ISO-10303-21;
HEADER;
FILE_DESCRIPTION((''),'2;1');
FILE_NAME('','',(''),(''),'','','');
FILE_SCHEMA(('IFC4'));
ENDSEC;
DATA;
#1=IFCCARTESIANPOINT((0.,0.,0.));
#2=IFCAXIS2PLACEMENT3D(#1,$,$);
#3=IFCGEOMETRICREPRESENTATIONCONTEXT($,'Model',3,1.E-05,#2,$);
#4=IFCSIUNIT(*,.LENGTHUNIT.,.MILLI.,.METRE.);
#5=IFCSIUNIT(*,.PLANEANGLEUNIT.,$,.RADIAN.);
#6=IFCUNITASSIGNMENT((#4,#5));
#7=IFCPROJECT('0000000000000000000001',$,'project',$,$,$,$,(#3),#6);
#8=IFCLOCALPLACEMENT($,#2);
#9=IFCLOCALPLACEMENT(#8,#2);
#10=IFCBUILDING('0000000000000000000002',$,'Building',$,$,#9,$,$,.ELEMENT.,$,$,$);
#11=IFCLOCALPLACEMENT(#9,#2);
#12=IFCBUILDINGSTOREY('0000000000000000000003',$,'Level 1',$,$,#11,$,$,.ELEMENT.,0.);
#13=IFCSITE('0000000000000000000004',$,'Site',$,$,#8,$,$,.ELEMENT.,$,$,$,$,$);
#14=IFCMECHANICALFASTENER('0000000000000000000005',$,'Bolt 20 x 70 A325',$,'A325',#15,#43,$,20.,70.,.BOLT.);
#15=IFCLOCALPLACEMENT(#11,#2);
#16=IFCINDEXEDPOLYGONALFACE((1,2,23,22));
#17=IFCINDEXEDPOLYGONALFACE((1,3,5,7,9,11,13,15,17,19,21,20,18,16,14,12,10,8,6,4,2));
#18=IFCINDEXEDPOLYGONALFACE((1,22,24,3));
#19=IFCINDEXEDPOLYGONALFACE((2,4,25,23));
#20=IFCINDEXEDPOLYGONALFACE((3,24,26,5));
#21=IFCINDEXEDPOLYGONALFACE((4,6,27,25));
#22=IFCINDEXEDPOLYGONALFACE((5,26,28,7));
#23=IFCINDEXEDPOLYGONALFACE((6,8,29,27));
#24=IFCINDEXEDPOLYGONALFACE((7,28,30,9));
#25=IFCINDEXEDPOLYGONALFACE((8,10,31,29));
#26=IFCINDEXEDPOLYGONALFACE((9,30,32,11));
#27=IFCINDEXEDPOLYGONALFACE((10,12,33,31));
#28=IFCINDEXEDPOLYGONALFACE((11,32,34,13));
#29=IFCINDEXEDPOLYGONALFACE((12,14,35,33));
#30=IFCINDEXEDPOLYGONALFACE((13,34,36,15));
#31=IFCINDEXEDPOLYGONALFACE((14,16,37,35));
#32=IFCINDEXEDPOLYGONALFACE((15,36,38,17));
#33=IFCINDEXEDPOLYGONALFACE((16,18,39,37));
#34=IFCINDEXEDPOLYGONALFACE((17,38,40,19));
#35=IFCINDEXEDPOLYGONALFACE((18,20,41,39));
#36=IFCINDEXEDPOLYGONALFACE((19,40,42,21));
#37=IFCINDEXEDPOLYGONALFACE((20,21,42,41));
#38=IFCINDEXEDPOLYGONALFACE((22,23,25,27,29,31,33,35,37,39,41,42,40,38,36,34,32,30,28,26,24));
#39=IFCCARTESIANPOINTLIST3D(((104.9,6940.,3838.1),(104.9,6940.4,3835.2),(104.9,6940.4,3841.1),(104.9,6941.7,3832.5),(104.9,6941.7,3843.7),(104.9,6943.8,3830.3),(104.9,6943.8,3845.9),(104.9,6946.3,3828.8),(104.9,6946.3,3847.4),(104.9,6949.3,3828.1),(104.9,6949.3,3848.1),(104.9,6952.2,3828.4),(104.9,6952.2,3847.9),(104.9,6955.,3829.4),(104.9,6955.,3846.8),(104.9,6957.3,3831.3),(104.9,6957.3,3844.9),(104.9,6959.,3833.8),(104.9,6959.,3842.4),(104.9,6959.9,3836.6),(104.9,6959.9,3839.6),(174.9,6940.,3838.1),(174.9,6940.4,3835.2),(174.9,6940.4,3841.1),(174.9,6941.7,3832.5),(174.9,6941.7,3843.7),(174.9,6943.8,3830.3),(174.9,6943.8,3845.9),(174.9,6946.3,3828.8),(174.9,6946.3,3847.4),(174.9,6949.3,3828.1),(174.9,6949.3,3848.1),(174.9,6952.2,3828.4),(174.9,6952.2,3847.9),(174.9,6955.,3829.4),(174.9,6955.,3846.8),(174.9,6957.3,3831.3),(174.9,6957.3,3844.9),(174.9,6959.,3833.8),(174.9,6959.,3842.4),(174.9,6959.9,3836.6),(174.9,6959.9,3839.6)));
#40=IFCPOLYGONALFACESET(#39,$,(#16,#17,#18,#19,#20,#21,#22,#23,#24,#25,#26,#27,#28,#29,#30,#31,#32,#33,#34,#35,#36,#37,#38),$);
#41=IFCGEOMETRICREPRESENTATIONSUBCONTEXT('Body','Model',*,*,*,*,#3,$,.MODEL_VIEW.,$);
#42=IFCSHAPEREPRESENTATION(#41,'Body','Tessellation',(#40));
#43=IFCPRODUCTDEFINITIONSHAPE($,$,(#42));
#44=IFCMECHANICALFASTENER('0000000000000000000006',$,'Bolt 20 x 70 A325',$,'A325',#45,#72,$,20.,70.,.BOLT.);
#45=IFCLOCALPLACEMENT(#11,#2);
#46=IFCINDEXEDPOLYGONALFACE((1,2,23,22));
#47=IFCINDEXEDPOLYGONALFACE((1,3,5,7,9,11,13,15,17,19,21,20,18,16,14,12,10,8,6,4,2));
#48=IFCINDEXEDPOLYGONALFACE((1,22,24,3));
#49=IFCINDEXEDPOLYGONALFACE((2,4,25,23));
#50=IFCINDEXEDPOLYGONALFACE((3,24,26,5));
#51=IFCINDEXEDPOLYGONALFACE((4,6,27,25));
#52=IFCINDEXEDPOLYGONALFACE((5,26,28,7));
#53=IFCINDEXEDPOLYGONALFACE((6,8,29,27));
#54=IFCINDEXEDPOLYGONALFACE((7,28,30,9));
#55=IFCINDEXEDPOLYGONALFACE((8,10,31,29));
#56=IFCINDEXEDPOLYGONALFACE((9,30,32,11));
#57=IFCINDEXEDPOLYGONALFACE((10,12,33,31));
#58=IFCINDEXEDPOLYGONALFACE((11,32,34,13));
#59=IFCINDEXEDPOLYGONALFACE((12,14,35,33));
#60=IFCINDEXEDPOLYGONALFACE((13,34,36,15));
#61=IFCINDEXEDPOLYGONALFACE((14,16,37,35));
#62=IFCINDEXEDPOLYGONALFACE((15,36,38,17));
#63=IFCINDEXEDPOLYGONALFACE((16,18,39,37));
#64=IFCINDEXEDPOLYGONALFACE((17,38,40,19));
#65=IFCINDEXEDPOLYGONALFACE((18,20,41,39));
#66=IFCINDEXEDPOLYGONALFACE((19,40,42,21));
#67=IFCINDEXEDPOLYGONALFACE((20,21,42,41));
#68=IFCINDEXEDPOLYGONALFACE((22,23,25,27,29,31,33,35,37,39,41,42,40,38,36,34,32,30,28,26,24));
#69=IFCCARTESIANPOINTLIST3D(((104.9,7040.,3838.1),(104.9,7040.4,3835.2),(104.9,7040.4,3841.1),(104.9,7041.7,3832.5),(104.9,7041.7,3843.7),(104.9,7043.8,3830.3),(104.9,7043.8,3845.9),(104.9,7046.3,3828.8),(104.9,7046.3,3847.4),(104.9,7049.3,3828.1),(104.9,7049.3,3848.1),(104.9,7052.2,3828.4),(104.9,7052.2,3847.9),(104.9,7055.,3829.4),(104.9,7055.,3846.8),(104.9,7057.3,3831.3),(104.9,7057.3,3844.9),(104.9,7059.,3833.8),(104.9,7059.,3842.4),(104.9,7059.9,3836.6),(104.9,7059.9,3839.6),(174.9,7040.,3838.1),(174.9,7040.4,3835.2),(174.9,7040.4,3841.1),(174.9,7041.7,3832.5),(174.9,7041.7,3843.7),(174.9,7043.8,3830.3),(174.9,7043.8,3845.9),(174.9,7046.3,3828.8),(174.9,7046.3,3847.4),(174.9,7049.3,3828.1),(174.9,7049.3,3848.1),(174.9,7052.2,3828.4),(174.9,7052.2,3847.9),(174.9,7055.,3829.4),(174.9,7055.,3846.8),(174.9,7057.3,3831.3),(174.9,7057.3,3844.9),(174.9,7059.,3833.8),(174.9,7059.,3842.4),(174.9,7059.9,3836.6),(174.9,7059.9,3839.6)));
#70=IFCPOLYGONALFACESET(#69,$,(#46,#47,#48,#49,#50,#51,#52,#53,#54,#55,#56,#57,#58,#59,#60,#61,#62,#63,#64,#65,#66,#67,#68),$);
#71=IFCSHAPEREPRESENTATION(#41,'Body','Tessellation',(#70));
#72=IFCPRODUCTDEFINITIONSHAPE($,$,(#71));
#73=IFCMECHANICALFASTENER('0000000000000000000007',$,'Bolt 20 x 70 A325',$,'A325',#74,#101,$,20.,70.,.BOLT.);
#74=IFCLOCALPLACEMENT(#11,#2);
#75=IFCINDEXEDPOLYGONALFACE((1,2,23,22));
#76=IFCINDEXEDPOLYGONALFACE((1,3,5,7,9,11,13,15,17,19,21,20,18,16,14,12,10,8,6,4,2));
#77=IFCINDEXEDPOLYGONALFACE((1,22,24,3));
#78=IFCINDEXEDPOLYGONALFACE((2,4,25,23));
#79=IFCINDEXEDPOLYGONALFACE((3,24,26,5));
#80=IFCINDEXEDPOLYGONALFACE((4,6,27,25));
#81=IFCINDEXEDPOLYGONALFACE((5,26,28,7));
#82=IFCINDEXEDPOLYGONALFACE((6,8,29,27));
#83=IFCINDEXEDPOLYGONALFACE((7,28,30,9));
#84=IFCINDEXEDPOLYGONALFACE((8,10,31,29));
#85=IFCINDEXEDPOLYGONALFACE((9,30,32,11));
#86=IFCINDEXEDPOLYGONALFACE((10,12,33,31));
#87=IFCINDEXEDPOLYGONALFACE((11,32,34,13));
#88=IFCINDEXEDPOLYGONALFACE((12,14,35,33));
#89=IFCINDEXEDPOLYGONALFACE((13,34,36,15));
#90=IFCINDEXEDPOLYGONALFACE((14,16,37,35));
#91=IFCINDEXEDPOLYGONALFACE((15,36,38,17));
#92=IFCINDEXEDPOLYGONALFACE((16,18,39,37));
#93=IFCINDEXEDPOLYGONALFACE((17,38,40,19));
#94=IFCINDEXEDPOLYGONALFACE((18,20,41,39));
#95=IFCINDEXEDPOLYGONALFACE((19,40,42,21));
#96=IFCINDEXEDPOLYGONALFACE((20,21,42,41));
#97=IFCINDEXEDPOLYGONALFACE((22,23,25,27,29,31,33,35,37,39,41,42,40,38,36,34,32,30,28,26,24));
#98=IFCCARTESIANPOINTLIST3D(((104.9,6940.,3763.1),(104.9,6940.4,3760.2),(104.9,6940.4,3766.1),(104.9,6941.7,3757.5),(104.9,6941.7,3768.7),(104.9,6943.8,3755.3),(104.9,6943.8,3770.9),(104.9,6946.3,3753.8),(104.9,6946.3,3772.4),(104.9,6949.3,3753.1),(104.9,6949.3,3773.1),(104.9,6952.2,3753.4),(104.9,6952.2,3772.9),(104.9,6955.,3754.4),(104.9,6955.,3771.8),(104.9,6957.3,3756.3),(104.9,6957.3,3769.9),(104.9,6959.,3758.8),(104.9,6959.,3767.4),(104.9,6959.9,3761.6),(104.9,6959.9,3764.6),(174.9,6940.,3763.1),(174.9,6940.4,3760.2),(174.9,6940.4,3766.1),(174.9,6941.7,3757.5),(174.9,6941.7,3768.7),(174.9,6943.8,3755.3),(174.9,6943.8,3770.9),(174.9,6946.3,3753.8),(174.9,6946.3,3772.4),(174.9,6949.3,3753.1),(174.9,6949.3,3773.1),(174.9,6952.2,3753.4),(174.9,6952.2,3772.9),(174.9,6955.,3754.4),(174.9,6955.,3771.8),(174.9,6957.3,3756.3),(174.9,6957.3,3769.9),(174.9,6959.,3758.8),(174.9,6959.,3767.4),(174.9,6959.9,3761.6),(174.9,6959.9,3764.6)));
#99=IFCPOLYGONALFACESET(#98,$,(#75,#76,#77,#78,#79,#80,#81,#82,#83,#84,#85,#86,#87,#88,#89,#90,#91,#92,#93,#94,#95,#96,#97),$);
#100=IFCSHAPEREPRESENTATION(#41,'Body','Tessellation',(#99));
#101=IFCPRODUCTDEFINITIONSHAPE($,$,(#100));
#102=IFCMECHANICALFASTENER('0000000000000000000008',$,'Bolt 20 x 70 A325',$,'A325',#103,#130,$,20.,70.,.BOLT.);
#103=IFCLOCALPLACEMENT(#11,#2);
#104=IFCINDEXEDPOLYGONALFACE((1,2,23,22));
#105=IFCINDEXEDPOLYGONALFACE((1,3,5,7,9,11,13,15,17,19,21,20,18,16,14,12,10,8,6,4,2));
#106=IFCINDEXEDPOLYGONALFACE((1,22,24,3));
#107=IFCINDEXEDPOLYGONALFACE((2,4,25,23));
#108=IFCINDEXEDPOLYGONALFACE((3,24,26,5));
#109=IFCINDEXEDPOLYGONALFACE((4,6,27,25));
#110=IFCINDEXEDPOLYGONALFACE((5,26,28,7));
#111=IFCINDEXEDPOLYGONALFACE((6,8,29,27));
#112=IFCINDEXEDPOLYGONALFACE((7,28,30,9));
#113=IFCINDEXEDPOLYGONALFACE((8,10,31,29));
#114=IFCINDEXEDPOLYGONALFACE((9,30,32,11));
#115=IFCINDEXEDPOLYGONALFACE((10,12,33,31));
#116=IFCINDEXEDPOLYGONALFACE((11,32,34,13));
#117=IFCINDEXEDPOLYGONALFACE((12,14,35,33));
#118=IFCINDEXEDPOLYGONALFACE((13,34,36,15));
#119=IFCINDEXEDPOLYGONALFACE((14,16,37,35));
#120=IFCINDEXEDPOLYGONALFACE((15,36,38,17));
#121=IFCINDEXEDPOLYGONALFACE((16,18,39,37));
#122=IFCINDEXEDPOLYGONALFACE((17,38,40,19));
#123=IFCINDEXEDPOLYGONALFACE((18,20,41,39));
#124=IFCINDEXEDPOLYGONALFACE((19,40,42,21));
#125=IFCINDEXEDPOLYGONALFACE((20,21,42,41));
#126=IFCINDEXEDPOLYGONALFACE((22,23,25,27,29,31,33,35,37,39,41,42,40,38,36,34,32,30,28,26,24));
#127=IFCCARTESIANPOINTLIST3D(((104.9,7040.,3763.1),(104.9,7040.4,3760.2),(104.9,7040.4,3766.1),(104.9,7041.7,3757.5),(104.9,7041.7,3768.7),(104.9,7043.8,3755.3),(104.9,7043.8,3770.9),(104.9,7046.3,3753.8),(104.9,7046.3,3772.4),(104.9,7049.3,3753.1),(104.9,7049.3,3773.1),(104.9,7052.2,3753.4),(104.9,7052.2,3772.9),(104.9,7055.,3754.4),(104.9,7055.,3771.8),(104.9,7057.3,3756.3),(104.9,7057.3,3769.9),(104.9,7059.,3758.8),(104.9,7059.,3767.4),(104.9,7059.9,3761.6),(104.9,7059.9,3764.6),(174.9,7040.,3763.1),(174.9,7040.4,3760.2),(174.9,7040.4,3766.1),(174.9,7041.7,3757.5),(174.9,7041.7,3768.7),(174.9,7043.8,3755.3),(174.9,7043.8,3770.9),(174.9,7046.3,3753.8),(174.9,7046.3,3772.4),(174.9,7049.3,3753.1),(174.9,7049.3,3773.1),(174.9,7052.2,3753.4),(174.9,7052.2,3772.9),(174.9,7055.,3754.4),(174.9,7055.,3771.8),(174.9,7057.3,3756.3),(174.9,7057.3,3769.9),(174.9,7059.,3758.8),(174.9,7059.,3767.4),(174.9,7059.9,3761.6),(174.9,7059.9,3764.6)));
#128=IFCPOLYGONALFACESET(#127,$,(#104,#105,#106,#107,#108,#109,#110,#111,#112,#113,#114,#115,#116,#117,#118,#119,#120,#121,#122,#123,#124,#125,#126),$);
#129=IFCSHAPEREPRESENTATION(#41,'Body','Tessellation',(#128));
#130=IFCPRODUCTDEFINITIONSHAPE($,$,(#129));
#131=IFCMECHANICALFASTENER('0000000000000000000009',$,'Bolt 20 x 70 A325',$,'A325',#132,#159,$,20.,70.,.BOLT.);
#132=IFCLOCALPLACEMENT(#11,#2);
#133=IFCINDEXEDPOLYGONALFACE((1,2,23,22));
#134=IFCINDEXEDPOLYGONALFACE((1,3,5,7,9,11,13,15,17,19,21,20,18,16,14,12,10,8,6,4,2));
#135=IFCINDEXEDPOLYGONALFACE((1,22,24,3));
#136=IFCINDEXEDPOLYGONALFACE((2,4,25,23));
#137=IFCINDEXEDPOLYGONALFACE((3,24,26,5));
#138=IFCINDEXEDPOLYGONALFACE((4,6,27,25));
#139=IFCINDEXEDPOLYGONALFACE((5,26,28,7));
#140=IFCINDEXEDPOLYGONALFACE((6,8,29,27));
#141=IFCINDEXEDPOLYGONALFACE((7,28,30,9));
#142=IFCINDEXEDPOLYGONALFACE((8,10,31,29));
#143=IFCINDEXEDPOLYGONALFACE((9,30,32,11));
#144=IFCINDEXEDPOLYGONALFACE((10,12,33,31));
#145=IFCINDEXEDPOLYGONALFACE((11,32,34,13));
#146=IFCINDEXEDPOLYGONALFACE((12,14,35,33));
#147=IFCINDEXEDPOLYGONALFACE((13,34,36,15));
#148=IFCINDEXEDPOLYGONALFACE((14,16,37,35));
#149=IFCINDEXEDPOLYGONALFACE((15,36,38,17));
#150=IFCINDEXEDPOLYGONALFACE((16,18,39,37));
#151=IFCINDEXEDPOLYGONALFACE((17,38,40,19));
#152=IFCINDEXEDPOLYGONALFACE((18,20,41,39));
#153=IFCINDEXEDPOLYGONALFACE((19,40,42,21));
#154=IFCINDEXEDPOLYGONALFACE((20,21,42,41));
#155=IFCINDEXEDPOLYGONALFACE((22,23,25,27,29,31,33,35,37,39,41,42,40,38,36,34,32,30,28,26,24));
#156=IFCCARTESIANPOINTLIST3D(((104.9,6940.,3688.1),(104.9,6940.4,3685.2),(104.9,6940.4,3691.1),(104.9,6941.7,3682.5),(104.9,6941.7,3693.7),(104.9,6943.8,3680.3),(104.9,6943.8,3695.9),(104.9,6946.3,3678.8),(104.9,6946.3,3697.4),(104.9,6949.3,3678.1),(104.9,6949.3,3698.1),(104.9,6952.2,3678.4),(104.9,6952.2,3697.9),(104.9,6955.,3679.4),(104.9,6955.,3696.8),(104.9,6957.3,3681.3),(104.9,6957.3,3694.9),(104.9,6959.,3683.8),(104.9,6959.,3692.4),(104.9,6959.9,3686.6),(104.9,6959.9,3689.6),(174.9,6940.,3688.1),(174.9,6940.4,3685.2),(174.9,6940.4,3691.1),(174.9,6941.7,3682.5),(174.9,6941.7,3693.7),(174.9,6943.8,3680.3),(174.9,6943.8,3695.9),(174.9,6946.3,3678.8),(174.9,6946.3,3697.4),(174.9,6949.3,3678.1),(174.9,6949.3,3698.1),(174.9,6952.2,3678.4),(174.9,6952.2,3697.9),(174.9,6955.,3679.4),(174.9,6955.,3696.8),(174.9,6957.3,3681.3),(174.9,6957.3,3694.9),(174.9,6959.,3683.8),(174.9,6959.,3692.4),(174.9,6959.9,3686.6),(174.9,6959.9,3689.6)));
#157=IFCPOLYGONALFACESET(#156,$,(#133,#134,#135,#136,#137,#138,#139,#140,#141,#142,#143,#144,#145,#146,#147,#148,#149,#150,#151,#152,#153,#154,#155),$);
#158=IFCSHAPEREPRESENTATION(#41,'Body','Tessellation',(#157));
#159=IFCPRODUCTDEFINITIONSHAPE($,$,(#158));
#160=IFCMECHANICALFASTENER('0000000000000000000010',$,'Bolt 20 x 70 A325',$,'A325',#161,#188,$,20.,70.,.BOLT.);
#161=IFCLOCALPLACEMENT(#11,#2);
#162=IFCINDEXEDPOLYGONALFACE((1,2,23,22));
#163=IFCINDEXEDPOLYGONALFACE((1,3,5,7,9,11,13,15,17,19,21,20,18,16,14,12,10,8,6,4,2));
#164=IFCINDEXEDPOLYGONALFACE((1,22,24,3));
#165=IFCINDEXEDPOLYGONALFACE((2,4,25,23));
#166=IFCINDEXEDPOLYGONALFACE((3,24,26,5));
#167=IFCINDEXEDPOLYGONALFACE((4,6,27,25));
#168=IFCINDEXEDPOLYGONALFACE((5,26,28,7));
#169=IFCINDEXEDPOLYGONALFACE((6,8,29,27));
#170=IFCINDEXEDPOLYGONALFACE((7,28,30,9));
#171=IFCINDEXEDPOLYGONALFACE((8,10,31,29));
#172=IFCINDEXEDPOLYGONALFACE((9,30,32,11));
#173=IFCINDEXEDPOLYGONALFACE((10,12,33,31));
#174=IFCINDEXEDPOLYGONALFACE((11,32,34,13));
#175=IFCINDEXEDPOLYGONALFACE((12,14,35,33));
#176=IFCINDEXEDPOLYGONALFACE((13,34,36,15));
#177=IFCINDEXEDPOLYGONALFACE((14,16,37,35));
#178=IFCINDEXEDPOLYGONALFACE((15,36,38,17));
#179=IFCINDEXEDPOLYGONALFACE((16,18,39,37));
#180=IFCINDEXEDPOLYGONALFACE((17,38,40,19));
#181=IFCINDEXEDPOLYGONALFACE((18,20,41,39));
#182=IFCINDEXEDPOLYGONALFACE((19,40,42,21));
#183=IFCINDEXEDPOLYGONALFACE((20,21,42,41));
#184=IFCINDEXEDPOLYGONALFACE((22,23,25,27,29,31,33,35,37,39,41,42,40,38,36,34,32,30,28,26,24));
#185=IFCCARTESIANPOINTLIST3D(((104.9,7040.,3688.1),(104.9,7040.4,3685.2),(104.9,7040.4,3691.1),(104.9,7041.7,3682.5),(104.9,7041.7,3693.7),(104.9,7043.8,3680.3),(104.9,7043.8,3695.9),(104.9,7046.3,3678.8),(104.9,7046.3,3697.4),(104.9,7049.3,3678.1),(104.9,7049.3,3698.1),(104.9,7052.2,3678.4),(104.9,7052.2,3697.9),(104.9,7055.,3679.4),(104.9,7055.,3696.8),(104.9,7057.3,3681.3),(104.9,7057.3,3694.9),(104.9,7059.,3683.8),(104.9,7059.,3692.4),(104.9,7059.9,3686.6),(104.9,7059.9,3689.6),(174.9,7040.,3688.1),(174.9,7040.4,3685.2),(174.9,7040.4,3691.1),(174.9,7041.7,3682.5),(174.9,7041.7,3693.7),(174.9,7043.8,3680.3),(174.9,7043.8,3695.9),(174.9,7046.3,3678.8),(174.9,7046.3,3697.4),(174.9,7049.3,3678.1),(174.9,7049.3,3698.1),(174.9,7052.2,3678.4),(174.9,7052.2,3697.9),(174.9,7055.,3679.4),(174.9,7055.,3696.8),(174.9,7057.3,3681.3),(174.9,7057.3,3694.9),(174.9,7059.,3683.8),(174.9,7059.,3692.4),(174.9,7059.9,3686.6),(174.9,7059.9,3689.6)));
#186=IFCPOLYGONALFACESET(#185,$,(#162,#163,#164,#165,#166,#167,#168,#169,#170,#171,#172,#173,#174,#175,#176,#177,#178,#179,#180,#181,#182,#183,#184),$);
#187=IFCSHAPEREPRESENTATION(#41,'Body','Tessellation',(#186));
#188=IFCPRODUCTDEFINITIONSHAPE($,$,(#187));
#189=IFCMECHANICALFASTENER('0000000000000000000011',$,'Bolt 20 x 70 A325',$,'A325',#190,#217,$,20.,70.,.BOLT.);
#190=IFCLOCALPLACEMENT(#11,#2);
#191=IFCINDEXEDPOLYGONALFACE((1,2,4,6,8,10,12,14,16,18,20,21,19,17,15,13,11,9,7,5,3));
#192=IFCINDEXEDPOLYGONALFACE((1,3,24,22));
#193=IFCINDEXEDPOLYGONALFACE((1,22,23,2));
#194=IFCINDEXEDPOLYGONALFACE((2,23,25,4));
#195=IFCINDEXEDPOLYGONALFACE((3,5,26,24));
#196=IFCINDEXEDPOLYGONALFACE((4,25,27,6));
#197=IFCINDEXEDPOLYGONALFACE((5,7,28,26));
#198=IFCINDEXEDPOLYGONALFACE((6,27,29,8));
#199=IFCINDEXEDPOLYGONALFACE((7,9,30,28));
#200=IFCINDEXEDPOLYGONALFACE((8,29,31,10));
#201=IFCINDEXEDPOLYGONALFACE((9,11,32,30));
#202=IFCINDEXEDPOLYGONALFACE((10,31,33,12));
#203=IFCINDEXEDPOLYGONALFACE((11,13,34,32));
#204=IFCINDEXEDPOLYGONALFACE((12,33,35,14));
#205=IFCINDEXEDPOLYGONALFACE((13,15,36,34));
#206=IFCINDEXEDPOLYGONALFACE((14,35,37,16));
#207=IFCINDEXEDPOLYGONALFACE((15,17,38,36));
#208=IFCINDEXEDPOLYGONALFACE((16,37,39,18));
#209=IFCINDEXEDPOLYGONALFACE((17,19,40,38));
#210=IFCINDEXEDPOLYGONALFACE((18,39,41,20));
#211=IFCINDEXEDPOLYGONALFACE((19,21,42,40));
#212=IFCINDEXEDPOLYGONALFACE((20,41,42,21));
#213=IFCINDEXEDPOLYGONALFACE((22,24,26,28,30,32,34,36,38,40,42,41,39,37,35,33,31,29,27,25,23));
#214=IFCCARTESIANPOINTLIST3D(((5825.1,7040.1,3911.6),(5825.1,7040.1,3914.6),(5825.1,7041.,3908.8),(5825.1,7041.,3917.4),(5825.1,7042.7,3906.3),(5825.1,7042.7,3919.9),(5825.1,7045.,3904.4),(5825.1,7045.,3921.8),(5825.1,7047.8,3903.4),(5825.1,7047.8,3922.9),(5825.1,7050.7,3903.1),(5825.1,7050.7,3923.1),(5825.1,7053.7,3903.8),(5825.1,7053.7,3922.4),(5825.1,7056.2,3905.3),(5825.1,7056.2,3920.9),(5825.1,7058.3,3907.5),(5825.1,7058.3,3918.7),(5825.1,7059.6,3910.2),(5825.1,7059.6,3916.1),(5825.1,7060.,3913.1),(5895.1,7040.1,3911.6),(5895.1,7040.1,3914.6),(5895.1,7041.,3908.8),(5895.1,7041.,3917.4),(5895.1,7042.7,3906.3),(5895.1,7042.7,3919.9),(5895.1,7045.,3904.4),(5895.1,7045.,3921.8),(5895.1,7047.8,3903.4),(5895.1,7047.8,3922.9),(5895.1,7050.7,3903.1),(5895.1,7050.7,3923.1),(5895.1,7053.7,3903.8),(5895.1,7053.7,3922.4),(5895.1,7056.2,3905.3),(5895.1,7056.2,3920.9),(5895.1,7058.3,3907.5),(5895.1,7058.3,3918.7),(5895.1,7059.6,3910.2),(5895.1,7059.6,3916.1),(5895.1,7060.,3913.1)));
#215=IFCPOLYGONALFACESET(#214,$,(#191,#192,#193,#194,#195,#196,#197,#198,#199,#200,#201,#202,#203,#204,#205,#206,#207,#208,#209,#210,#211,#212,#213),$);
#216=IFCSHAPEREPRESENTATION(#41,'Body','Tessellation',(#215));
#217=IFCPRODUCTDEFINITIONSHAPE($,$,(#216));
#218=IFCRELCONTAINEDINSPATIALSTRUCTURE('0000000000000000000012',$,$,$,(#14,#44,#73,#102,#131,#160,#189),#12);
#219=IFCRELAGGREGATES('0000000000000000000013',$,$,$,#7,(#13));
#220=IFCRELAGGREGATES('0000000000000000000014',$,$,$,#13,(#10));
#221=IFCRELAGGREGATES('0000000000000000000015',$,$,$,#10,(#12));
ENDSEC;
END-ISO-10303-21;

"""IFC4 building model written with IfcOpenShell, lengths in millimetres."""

from ifc_helpers import new_model, si_unit, frame, origin, origin_2d, place, context, subcontext, project, spatial, circle, extrude, element, save


model = new_model("IFC4")

# Units and contexts
model_context = context("Model", 3, precision=1e-05, world=origin())
body_context = subcontext(model_context, "Body", "Model", "MODEL_VIEW")
ifc_project = project(units=[si_unit("LENGTHUNIT", "METRE", prefix="MILLI"), si_unit("PLANEANGLEUNIT", "RADIAN")], contexts=[model_context])

# Site, building, storey
site_placement = place(None, origin())
site = spatial("IfcSite", under=ifc_project, at=site_placement, Name="Site", CompositionType="ELEMENT")
building_placement = place(site_placement, origin())
building = spatial("IfcBuilding", under=site, at=building_placement, Name="Building", CompositionType="ELEMENT")
storey_placement = place(building_placement, origin())
storey = spatial("IfcBuildingStorey", under=building, at=storey_placement, Name="Level 1", CompositionType="ELEMENT", Elevation=0.0)

# Mechanical fasteners
for number, where, z_axis, x_axis, name in (
    (1, (174.9, 6950.0, 3838.1), (-1.0, 0.0, 0.0), (0.0, -1.0, 0.0), "Bolt 20 x 70 A325"),
    (2, (174.9, 7050.0, 3838.1), (-1.0, 0.0, 0.0), (0.0, -1.0, 0.0), "Bolt 20 x 70 A325"),
    (3, (174.9, 6950.0, 3763.1), (-1.0, 0.0, 0.0), (0.0, -1.0, 0.0), "Bolt 20 x 70 A325"),
    (4, (174.9, 7050.0, 3763.1), (-1.0, 0.0, 0.0), (0.0, -1.0, 0.0), "Bolt 20 x 70 A325"),
    (5, (174.9, 6950.0, 3688.1), (-1.0, 0.0, 0.0), (0.0, -1.0, 0.0), "Bolt 20 x 70 A325"),
    (6, (174.9, 7050.0, 3688.1), (-1.0, 0.0, 0.0), (0.0, -1.0, 0.0), "Bolt 20 x 70 A325"),
    (7, (5825.1, 7050.0, 3913.1), (1.0, 0.0, 0.0), (0.0, 1.0, 0.0), "Bolt 20 x 70 A325"),
):
    element("IfcMechanicalFastener", number, at=place(storey_placement, frame(where, z_axis=z_axis, x_axis=x_axis)), inside=storey, Name=name, ObjectType="A325", NominalDiameter=20.0, NominalLength=70.0, PredefinedType="BOLT", context=body_context, shape_type="SweptSolid", body=[
        extrude(circle(Radius=10.0, at=origin_2d()), origin(), (0.0, 0.0, 1.0), 70.0),
    ])

save(model, "model.ifc")
